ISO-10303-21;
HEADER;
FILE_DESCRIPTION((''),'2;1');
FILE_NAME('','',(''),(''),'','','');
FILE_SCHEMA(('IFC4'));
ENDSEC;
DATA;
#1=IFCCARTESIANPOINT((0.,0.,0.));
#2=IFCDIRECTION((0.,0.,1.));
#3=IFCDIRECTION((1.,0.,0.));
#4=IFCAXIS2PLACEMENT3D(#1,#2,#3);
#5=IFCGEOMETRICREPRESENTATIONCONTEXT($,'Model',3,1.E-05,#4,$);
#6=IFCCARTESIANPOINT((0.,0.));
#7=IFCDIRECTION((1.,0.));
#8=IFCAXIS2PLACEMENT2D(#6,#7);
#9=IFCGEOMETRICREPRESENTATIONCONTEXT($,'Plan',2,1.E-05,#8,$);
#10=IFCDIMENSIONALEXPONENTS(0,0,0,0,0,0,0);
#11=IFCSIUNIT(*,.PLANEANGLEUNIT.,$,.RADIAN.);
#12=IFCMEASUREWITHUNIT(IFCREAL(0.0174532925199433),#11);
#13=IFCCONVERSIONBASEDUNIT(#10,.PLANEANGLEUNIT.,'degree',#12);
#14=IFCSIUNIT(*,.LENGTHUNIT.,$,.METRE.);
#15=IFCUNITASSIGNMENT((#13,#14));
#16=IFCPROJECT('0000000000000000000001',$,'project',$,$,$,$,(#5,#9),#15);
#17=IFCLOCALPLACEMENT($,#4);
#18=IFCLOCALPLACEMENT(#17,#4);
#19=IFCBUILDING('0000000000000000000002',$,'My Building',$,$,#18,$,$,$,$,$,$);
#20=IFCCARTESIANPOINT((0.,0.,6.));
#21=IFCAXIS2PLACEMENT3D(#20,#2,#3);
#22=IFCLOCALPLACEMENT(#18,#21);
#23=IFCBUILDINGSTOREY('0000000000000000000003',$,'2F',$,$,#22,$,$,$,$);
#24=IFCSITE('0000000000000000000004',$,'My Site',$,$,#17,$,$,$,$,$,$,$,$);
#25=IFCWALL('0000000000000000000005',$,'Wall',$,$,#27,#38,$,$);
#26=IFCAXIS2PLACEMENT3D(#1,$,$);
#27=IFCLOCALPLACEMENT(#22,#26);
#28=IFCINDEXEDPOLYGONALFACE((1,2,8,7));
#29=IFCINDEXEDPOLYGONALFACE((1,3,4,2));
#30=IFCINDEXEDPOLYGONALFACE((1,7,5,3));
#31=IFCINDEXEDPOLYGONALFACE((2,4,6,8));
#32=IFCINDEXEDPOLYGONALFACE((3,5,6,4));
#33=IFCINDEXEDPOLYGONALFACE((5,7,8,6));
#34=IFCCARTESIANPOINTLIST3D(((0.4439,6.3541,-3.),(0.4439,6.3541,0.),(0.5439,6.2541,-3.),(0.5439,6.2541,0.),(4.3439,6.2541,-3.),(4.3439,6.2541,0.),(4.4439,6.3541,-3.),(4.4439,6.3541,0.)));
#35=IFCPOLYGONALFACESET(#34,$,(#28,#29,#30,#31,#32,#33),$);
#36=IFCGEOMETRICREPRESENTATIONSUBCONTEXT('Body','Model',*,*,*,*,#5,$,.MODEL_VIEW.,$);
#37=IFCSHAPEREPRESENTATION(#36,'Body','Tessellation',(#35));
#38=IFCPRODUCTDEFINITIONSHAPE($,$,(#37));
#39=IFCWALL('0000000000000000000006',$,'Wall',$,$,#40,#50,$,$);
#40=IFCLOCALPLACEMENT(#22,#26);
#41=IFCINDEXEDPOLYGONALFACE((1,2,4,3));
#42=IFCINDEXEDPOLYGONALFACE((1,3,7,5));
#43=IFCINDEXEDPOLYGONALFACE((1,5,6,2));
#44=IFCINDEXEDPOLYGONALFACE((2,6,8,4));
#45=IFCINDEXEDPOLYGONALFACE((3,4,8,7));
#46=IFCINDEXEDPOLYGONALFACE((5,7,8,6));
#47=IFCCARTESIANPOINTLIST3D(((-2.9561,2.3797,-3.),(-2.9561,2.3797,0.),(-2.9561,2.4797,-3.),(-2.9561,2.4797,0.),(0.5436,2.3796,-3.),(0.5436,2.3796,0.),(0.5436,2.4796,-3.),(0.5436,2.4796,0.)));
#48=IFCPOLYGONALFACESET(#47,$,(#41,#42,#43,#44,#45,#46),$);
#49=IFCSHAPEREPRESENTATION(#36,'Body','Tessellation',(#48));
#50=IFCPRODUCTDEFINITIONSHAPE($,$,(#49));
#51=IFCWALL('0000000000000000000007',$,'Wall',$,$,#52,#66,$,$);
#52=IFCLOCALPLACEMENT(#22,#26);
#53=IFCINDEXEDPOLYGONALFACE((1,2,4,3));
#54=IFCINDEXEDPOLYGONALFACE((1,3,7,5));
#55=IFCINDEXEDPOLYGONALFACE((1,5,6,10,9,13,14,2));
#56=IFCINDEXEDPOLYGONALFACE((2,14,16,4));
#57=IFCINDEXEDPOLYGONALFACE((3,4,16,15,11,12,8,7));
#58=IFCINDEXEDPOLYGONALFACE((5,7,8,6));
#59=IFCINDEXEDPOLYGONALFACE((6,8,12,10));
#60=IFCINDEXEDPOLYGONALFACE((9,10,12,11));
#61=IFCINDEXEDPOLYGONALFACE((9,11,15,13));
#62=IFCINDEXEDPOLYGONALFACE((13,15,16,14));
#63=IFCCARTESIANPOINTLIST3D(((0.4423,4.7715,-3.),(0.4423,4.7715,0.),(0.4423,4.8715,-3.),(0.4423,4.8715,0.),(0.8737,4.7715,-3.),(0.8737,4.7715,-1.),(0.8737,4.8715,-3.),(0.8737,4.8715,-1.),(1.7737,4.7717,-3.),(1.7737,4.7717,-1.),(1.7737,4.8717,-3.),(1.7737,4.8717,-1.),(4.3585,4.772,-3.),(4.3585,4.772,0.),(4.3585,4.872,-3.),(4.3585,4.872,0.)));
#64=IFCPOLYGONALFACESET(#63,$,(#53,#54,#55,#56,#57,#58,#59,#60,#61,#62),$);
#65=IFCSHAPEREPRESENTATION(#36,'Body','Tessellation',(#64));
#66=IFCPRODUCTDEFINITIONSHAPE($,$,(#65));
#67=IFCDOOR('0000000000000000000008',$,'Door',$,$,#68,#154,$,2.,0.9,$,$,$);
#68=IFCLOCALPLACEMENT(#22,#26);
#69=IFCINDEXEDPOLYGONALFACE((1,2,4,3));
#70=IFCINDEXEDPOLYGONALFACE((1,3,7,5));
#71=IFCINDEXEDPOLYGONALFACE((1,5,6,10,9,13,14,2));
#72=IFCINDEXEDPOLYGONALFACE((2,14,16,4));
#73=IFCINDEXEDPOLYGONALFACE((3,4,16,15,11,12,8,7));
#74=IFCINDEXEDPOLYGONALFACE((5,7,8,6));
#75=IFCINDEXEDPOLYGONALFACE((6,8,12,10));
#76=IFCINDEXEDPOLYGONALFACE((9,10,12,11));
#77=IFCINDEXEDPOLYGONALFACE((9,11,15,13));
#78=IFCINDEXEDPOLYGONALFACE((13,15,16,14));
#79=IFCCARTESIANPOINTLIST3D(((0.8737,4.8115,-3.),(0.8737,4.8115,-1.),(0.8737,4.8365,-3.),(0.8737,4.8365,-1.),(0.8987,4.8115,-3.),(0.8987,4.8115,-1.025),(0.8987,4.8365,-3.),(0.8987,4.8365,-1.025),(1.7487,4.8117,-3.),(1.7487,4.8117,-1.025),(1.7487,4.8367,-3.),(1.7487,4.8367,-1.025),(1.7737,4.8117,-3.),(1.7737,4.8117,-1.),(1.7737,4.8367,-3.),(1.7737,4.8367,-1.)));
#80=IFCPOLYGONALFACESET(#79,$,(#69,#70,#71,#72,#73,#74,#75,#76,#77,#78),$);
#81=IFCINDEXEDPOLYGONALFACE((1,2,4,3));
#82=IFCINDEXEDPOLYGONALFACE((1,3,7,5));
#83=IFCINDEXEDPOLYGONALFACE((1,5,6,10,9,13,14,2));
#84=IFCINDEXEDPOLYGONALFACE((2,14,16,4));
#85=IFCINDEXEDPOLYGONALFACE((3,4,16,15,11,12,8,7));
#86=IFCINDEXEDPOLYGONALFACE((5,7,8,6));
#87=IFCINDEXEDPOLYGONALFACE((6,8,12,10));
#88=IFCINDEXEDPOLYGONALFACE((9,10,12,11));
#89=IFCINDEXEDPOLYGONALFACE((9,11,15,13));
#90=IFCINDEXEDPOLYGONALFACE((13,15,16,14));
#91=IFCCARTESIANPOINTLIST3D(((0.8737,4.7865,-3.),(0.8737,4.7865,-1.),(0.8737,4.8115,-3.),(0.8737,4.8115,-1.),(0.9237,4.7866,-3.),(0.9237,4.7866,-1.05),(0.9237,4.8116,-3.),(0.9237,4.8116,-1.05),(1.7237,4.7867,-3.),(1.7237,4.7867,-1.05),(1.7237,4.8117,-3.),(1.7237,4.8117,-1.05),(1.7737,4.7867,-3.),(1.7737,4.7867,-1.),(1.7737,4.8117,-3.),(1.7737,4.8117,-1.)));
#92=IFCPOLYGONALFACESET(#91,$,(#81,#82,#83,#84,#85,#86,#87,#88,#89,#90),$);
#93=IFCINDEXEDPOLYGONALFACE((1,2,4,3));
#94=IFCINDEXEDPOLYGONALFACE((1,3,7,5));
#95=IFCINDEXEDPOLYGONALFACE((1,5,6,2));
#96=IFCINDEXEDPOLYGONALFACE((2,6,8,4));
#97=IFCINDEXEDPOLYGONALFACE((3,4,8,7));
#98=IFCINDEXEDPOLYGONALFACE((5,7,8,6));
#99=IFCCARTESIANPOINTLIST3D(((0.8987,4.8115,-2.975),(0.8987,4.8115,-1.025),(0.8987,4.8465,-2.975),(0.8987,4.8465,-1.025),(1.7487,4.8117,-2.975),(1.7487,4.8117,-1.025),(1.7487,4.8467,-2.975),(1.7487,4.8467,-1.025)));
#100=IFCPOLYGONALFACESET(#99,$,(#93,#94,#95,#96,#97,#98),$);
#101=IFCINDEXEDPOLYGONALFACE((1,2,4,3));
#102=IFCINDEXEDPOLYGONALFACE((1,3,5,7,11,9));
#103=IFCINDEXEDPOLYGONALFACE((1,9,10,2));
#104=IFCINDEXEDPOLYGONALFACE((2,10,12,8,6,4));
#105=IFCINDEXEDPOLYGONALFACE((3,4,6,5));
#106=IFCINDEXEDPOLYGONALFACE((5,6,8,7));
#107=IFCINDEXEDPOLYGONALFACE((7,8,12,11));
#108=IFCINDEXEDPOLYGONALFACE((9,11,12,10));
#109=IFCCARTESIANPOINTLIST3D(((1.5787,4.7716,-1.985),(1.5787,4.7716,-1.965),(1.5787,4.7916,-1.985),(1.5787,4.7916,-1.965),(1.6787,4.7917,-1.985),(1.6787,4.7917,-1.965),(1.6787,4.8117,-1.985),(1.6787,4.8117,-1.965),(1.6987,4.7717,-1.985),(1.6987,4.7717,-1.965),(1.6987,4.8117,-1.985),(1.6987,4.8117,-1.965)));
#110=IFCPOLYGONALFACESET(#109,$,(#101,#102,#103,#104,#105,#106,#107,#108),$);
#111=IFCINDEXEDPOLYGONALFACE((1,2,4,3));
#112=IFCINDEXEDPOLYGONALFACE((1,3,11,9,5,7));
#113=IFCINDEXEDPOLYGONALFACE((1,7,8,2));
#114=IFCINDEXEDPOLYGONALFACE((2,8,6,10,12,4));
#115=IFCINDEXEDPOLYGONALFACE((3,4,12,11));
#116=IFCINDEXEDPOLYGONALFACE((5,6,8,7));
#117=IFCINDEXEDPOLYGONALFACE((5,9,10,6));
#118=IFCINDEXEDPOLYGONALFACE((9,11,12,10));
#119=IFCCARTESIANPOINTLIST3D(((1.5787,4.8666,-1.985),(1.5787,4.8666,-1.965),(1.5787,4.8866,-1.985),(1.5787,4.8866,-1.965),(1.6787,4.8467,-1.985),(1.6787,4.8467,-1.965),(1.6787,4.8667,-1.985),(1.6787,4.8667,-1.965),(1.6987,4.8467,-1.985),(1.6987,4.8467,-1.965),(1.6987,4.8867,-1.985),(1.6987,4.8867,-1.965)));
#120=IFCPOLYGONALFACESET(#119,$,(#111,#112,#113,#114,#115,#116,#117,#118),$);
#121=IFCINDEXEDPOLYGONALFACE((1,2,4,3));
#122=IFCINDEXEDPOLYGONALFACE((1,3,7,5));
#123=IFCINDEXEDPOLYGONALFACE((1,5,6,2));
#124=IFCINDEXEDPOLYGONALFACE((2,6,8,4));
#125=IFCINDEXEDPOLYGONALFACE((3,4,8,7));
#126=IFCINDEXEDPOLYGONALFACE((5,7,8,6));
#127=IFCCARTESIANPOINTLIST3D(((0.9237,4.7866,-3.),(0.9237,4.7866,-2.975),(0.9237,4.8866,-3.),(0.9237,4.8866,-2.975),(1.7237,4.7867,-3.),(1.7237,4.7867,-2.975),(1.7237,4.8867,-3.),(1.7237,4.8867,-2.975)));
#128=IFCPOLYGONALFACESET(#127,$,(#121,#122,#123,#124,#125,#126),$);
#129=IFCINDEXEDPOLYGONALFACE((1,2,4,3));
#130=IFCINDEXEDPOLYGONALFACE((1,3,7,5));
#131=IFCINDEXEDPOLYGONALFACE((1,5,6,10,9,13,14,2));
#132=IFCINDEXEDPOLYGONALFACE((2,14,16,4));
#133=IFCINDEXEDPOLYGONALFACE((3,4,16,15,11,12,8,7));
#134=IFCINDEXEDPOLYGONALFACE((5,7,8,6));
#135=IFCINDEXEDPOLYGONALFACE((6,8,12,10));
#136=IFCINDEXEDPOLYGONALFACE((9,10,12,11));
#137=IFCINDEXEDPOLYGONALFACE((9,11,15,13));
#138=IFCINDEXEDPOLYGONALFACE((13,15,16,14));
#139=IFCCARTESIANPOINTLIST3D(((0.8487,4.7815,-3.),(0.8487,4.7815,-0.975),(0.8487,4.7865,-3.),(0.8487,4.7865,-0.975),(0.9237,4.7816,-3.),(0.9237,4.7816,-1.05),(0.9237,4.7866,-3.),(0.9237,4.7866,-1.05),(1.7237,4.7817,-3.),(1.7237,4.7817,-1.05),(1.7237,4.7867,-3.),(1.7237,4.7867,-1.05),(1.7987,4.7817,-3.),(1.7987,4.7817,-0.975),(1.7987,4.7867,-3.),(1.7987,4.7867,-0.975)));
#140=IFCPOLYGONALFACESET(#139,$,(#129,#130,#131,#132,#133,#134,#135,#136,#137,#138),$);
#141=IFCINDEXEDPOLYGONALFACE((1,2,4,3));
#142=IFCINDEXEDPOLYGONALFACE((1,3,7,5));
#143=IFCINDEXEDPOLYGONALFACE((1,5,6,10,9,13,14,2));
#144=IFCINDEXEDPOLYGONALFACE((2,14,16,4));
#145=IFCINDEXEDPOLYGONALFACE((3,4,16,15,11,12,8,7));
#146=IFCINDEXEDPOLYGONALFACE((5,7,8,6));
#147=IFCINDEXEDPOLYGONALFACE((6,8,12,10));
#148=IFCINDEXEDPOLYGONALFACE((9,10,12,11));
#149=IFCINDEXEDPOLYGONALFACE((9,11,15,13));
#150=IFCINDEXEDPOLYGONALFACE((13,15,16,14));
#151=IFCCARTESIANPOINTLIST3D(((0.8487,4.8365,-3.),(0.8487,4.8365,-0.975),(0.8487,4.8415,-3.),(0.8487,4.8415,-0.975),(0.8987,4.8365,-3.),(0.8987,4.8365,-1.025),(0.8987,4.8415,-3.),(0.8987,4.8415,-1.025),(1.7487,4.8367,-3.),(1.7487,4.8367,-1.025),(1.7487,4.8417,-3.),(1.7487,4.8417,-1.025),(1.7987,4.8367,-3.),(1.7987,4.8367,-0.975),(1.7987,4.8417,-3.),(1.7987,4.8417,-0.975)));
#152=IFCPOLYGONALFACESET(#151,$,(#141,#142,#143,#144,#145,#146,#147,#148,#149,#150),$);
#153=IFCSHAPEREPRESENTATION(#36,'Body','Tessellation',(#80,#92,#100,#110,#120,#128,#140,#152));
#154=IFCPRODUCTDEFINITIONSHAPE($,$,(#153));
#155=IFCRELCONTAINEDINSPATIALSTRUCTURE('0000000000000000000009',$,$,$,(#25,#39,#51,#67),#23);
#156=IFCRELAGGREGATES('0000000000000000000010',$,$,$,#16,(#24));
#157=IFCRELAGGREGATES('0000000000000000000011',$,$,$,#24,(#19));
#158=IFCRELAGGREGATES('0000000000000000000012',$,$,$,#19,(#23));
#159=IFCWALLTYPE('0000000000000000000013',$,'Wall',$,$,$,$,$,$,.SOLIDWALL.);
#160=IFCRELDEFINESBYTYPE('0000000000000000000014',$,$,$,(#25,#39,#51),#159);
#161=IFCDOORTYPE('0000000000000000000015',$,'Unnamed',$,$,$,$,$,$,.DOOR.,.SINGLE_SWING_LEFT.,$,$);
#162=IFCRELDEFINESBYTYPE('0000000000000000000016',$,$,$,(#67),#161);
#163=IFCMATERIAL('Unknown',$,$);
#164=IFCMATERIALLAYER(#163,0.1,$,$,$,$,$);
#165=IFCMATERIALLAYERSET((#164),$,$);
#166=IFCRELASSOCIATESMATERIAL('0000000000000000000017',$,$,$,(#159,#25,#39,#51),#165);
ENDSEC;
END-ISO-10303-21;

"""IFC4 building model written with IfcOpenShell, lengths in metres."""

from ifc_helpers import new_model, entity, si_unit, converted_unit, frame, origin_with_axes, origin_2d_with_axis, place, context, subcontext, project, spatial, line, indexed_curve, outline, extrude, shape, source, transform, mapped, material, layer, layer_set, layer_usage, type_object, type_shapes, element, fill, save


model = new_model("IFC4")

# Units and contexts
model_context = context("Model", 3, precision=1e-05, world=origin_with_axes())
plan_context = context("Plan", 2, precision=1e-05, world=origin_2d_with_axis())
body_context_1 = subcontext(model_context, "Body", "Model", "MODEL_VIEW")
body_context_2 = subcontext(plan_context, "Body", "Plan", "PLAN_VIEW")
ifc_project = project(units=[converted_unit("PLANEANGLEUNIT", "degree", entity("IfcReal", 0.0174532925199433), si_unit("PLANEANGLEUNIT", "RADIAN"), dimensions=[0, 0, 0, 0, 0, 0, 0]), si_unit("LENGTHUNIT", "METRE")], contexts=[model_context, plan_context])

# Site, building, storey
site_placement = place(None, origin_with_axes())
site = spatial("IfcSite", under=ifc_project, at=site_placement, Name="My Site")
building_placement = place(site_placement, origin_with_axes())
building = spatial("IfcBuilding", under=site, at=building_placement, Name="My Building")
storey_placement = place(building_placement, frame((0.0, 0.0, 6.0), z_axis=(0.0, 0.0, 1.0), x_axis=(1.0, 0.0, 0.0)))
storey = spatial("IfcBuildingStorey", under=building, at=storey_placement, Name="2F")

# Walls
ifc_material = material(Name="Unknown")
ifc_layer = layer(ifc_material, 0.1)
ifc_layer_set = layer_set([ifc_layer])
ifc_layer_usage_1 = layer_usage(ifc_layer_set, "AXIS2", "POSITIVE", 0.0)
wall_type = type_object("IfcWallType", Name="Wall", PredefinedType="SOLIDWALL", material=ifc_layer_set)
wall_1_placement = place(storey_placement, frame((4.4439, 6.3541, -3.0), z_axis=(0.0, 0.0, 1.0), x_axis=(-1.0, 0.0, 0.0)))
element("IfcWall", 1, at=wall_1_placement, inside=storey, type_object=wall_type, material=ifc_layer_usage_1, Name="Wall", context=body_context_1, shape_type="SweptSolid", body=[
    extrude(outline(indexed_curve([(0.0, 0.0), (0.1, 0.1), (3.9, 0.1), (4.0, 0.0)], segments=[line(1, 2, 3, 4, 1)])), origin_with_axes(), (0.0, 0.0, 1.0), 3.0),
])
ifc_layer_usage_2 = layer_usage(ifc_layer_set, "AXIS2", "POSITIVE", 0.0)
wall_2_placement = place(storey_placement, frame((0.5436, 2.4796, -3.0), z_axis=(0.0, 0.0, 1.0), x_axis=(-1.0, 0.000025, 0.0)))
element("IfcWall", 2, at=wall_2_placement, inside=storey, type_object=wall_type, material=ifc_layer_usage_2, Name="Wall", context=body_context_1, shape_type="SweptSolid", body=[
    extrude(outline(indexed_curve([(0.0, 0.0), (0.0, 0.1), (3.4997, 0.1), (3.4997, 0.0)], segments=[line(1, 2, 3, 4, 1)])), origin_with_axes(), (0.0, 0.0, 1.0), 3.0),
])

# Shared definitions
shared_shape_1 = source(origin_with_axes(), body_context_1, "Body", "SweptSolid", [
    extrude(outline(indexed_curve([(0.0, 0.0), (0.9, 0.0), (0.9, 2.0), (0.0, 2.0)], segments=[line(1, 2, 3, 4, 1)])), frame((0.0, -0.6, 0.0), z_axis=(0.0, -1.0, 0.0), x_axis=(1.0, 0.0, 0.0)), (0.0, 0.0, -1.0), 1.2),
])
door_type = type_object("IfcDoorType", Name="Unnamed", OperationType="SINGLE_SWING_LEFT", PredefinedType="DOOR")
shared_shape_2 = source(origin_with_axes(), body_context_1, "Body", "SweptSolid", [
    extrude(outline(indexed_curve([(0.0, 0.0), (0.0, 2.0), (0.9, 2.0), (0.9, 0.0), (0.875, 0.0), (0.875, 1.975), (0.025, 1.975), (0.025, 0.0)], segments=[line(1, 2, 3, 4, 5, 6, 7, 8, 1)])), frame((0.0, 0.025, 0.0), z_axis=(0.0, -1.0, 0.0), x_axis=(1.0, 0.0, 0.0)), (0.0, 0.0, -1.0), 0.025),
    extrude(outline(indexed_curve([(0.0, 0.0), (0.0, 2.0), (0.9, 2.0), (0.9, 0.0), (0.85, 0.0), (0.85, 1.95), (0.05, 1.95), (0.05, 0.0)], segments=[line(1, 2, 3, 4, 5, 6, 7, 8, 1)])), frame((0.0, 0.0, 0.0), z_axis=(0.0, -1.0, 0.0), x_axis=(1.0, 0.0, 0.0)), (0.0, 0.0, -1.0), 0.025),
    extrude(outline(indexed_curve([(0.0, 0.0), (0.85, 0.0), (0.85, 0.035), (0.0, 0.035)], segments=[line(1, 2, 3, 4, 1)])), frame((0.025, 0.025, 0.025), z_axis=(0.0, 0.0, 1.0), x_axis=(1.0, 0.0, 0.0)), (0.0, 0.0, 1.0), 1.95),
    extrude(outline(indexed_curve([(0.0, 0.0), (0.0, -0.04), (-0.12, -0.04), (-0.12, -0.02), (-0.02, -0.02), (-0.02, 0.0)], segments=[line(1, 2, 3, 4, 5, 6, 1)])), frame((0.825, 0.025, 1.015), z_axis=(0.0, 0.0, 1.0), x_axis=(1.0, 0.0, 0.0)), (0.0, 0.0, 1.0), 0.02),
    extrude(outline(indexed_curve([(0.0, 0.0), (0.0, 0.04), (-0.12, 0.04), (-0.12, 0.02), (-0.02, 0.02), (-0.02, 0.0)], segments=[line(1, 2, 3, 4, 5, 6, 1)])), frame((0.825, 0.06, 1.015), z_axis=(0.0, 0.0, 1.0), x_axis=(1.0, 0.0, 0.0)), (0.0, 0.0, 1.0), 0.02),
    extrude(outline(indexed_curve([(0.0, 0.0), (0.8, 0.0), (0.8, 0.1), (0.0, 0.1)], segments=[line(1, 2, 3, 4, 1)])), frame((0.05, 0.0, 0.0), z_axis=(0.0, 0.0, 1.0), x_axis=(1.0, 0.0, 0.0)), (0.0, 0.0, 1.0), 0.025),
    extrude(outline(indexed_curve([(0.0, 0.0), (0.0, 2.025), (0.95, 2.025), (0.95, 0.0), (0.875, 0.0), (0.875, 1.95), (0.075, 1.95), (0.075, 0.0)], segments=[line(1, 2, 3, 4, 5, 6, 7, 8, 1)])), frame((-0.025, -0.005, 0.0), z_axis=(0.0, -1.0, 0.0), x_axis=(1.0, 0.0, 0.0)), (0.0, 0.0, -1.0), 0.005),
    extrude(outline(indexed_curve([(0.0, 0.0), (0.0, 2.025), (0.95, 2.025), (0.95, 0.0), (0.9, 0.0), (0.9, 1.975), (0.05, 1.975), (0.05, 0.0)], segments=[line(1, 2, 3, 4, 5, 6, 7, 8, 1)])), frame((-0.025, 0.05, 0.0), z_axis=(0.0, -1.0, 0.0), x_axis=(1.0, 0.0, 0.0)), (0.0, 0.0, -1.0), 0.005),
])
shared_shape_3 = source(origin_with_axes(), body_context_2, "Body", "Curve2D", [
    entity("IfcIndexedPolyCurve", entity("IfcCartesianPointList2D", [[0.0, 0.0], [0.0, 0.05], [0.025, 0.05], [0.025, 0.025], [0.05, 0.025], [0.05, 0.0]]), [entity("IfcLineIndex", [1, 2, 3, 4, 5, 6, 1])]),
    entity("IfcIndexedPolyCurve", entity("IfcCartesianPointList2D", [[0.9, 0.0], [0.9, 0.05], [0.875, 0.05], [0.875, 0.025], [0.85, 0.025], [0.85, 0.0]]), [entity("IfcLineIndex", [1, 2, 3, 4, 5, 6, 1])]),
    entity("IfcTrimmedCurve", entity("IfcEllipse", entity("IfcAxis2Placement2D", entity("IfcCartesianPoint", [0.06, 0.05]), entity("IfcDirection", [1.0, 0.0])), 0.815, 0.85), [entity("IfcCartesianPoint", [0.875, 0.05])], [entity("IfcCartesianPoint", [0.06, 0.9])], True, "CARTESIAN"),
    entity("IfcIndexedPolyCurve", entity("IfcCartesianPointList2D", [[0.025, 0.05], [0.06, 0.05], [0.06, 0.9], [0.025, 0.9]]), [entity("IfcLineIndex", [1, 2, 3, 4, 1])]),
])
type_shapes(door_type, [shared_shape_2, shared_shape_3])

# Wall, opening, door
ifc_layer_usage_3 = layer_usage(ifc_layer_set, "AXIS2", "POSITIVE", 0.0)
wall_3_placement = place(storey_placement, frame((4.3585, 4.872, -3.0), z_axis=(0.0, 0.0, 1.0), x_axis=(-1.0, -0.00013, 0.0)))
wall_3 = element("IfcWall", 3, at=wall_3_placement, inside=storey, type_object=wall_type, material=ifc_layer_usage_3, Name="Wall", context=body_context_1, shape_type="SweptSolid", body=[
    extrude(outline(indexed_curve([(0.0, 0.0), (0.0, 0.1), (3.9162, 0.1), (3.9162, 0.0)], segments=[line(1, 2, 3, 4, 1)])), origin_with_axes(), (0.0, 0.0, 1.0), 3.0),
])
opening_1_placement = place(wall_3_placement, frame((2.5848, 0.0, 0.0), z_axis=(0.0, 0.0, 1.0), x_axis=(1.0, 0.0, 0.0)))
opening_1 = element("IfcOpeningElement", 4, at=opening_1_placement, cuts=wall_3, PredefinedType="OPENING", context=body_context_1, shape_type="MappedRepresentation", body=[
    mapped(shared_shape_1, transform((0.0, 0.0, 0.0), x_axis=(1.0, 0.0, 0.0), y_axis=(0.0, 1.0, 0.0), z_axis=(0.0, 0.0, 1.0), scale=1.0)),
])
door_1_placement = place(opening_1_placement, frame((0.9, 0.085, 0.0), z_axis=(0.0, 0.0, 1.0), x_axis=(-1.0, 0.0, 0.0)))
door_1 = element("IfcDoor", 5, at=door_1_placement, inside=storey, type_object=door_type, Name="Door", OverallHeight=2.0, OverallWidth=0.9, shapes=[
    shape(body_context_1, "Body", "MappedRepresentation", [mapped(shared_shape_2, transform((0.0, 0.0, 0.0), x_axis=(1.0, 0.0, 0.0), y_axis=(0.0, 1.0, 0.0), z_axis=(0.0, 0.0, 1.0), scale=1.0))]),
    shape(body_context_2, "Body", "MappedRepresentation", [mapped(shared_shape_3, transform((0.0, 0.0, 0.0), x_axis=(1.0, 0.0, 0.0), y_axis=(0.0, 1.0, 0.0), z_axis=(0.0, 0.0, 1.0), scale=1.0))]),
])
fill(opening_1, door_1)

save(model, "model.ifc")
